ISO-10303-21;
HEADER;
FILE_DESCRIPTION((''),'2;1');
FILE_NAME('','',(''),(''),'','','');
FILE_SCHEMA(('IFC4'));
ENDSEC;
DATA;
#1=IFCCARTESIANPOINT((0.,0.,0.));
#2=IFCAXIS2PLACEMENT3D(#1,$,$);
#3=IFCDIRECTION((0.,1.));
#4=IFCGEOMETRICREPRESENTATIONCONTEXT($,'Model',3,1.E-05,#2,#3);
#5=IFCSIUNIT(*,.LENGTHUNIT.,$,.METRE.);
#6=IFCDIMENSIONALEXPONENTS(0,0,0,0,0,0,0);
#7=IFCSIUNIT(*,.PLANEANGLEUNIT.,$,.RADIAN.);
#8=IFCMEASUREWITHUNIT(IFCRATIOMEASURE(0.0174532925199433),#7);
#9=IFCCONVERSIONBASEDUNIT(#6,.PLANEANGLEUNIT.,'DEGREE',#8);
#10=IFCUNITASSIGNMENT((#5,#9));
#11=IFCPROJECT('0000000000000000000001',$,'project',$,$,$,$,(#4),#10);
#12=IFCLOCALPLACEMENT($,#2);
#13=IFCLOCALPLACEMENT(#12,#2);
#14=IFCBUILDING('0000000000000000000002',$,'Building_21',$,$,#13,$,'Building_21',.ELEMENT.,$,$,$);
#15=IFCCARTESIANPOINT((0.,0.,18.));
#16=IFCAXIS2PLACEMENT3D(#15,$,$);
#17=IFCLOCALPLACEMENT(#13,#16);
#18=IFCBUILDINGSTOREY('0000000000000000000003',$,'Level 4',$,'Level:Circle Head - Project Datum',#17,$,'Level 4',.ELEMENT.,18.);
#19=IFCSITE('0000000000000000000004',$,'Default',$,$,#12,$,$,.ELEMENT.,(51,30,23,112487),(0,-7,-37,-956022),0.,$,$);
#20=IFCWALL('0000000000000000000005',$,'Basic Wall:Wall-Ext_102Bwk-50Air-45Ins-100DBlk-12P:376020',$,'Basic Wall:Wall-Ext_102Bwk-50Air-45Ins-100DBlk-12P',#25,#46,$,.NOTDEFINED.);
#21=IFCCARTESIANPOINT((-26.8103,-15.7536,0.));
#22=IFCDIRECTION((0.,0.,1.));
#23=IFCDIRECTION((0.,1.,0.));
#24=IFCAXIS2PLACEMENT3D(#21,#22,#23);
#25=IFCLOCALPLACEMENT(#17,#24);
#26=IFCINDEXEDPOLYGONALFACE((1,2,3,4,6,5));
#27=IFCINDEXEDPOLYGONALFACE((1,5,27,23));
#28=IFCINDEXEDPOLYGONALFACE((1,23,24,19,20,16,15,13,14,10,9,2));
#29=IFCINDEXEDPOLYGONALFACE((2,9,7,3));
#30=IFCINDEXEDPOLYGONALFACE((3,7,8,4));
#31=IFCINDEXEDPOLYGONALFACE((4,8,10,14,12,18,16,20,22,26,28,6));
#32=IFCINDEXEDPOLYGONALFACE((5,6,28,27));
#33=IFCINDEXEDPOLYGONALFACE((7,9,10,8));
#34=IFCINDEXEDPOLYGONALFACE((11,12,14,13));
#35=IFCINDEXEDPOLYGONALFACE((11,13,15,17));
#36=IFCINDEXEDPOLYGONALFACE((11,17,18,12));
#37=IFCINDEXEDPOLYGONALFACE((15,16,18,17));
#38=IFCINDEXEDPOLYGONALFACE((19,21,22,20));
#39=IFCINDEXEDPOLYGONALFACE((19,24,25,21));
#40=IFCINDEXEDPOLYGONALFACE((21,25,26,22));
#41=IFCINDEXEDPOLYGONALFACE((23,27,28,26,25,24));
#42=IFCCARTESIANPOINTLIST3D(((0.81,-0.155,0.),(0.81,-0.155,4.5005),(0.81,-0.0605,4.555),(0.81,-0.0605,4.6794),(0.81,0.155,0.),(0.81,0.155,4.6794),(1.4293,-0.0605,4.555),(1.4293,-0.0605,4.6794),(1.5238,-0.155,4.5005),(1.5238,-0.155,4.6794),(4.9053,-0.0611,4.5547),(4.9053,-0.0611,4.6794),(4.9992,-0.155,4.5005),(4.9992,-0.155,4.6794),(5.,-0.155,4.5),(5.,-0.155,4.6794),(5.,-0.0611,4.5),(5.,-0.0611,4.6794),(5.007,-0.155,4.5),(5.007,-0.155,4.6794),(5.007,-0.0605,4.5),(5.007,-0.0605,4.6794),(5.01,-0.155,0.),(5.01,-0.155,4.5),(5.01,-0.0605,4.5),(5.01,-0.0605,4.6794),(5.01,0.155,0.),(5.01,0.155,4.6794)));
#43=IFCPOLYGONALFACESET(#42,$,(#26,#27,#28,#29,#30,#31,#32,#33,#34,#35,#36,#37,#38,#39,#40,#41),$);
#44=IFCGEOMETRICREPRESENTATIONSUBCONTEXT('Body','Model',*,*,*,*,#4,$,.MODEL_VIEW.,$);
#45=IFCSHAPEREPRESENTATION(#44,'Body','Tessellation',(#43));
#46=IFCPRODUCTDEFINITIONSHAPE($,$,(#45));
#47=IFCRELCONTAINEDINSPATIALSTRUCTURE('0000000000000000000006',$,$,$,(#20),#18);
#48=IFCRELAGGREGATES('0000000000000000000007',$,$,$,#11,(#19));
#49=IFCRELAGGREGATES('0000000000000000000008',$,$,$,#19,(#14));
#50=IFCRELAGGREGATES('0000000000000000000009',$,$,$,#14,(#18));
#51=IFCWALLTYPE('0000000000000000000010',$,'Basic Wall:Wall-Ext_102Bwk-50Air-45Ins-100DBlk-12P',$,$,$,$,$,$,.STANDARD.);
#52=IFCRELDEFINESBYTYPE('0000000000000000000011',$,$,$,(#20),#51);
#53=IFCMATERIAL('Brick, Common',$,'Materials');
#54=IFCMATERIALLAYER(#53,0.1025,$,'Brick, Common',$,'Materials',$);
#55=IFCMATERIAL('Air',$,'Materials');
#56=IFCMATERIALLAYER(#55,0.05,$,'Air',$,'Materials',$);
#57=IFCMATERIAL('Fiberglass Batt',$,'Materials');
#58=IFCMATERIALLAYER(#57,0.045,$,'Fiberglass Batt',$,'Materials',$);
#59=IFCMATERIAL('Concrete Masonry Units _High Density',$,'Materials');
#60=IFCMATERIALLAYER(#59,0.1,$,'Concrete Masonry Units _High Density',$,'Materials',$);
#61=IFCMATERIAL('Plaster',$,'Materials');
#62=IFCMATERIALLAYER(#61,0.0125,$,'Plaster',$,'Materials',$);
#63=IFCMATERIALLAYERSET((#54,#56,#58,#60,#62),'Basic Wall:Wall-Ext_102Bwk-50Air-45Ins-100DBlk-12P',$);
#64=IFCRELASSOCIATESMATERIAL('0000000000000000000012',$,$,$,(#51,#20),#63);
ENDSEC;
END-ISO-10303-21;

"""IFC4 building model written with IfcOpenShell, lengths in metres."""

from ifc_helpers import new_model, entity, si_unit, converted_unit, direction, frame, frame_2d, origin, place, context, subcontext, project, spatial, polyline, rectangle, extrude, clip, bounded_halfspace, material, layer, layer_set, layer_usage, type_object, element, save


model = new_model("IFC4")

# Units and contexts
model_context = context("Model", 3, precision=1e-05, world=origin(), true_north=direction((0.0, 1.0)))
body_context = subcontext(model_context, "Body", "Model", "MODEL_VIEW")
ifc_project = project(units=[si_unit("LENGTHUNIT", "METRE"), converted_unit("PLANEANGLEUNIT", "DEGREE", entity("IfcRatioMeasure", 0.0174532925199433), si_unit("PLANEANGLEUNIT", "RADIAN"), dimensions=[0, 0, 0, 0, 0, 0, 0])], contexts=[model_context])

# Site, building, storey
site_placement = place(None, origin())
site = spatial("IfcSite", under=ifc_project, at=site_placement, Name="Default", CompositionType="ELEMENT", RefLatitude=(51, 30, 23, 112487), RefLongitude=(0, -7, -37, -956022), RefElevation=0.0)
building_placement = place(site_placement, origin())
building = spatial("IfcBuilding", under=site, at=building_placement, Name="Building_21", LongName="Building_21", CompositionType="ELEMENT")
storey_placement = place(building_placement, frame((0.0, 0.0, 18.0)))
storey = spatial("IfcBuildingStorey", under=building, at=storey_placement, Name="Level 4", ObjectType="Level:Circle Head - Project Datum", LongName="Level 4", CompositionType="ELEMENT", Elevation=18.0)

# Shared definitions
ifc_material_1 = material(Name="Air", Category="Materials")

# Shared definitions
ifc_material_2 = material(Name="Brick, Common", Category="Materials")
ifc_layer_1 = layer(ifc_material_2, 0.1025, Name="Brick, Common", Category="Materials")
ifc_layer_2 = layer(ifc_material_1, 0.05, Name="Air", Category="Materials")
ifc_material_3 = material(Name="Fiberglass Batt", Category="Materials")
ifc_layer_3 = layer(ifc_material_3, 0.045, Name="Fiberglass Batt", Category="Materials")
ifc_material_4 = material(Name="Concrete Masonry Units _High Density", Category="Materials")
ifc_layer_4 = layer(ifc_material_4, 0.1, Name="Concrete Masonry Units _High Density", Category="Materials")
ifc_material_5 = material(Name="Plaster", Category="Materials")
ifc_layer_5 = layer(ifc_material_5, 0.0125, Name="Plaster", Category="Materials")
ifc_layer_set_1 = layer_set([ifc_layer_1, ifc_layer_2, ifc_layer_3, ifc_layer_4, ifc_layer_5], Name="Basic Wall:Wall-Ext_102Bwk-50Air-45Ins-100DBlk-12P")
wall_type = type_object("IfcWallType", Name="Basic Wall:Wall-Ext_102Bwk-50Air-45Ins-100DBlk-12P", PredefinedType="STANDARD", material=ifc_layer_set_1)

# Wall, opening
ifc_layer_usage_1 = layer_usage(ifc_layer_set_1, "AXIS2", "NEGATIVE", 0.155)
wall_1_placement = place(storey_placement, frame((-26.8103, -15.7536, 0.0), z_axis=(0.0, 0.0, 1.0), x_axis=(0.0, 1.0, 0.0)))
wall_1 = element("IfcWall", 1, at=wall_1_placement, inside=storey, type_object=wall_type, material=ifc_layer_usage_1, Name="Basic Wall:Wall-Ext_102Bwk-50Air-45Ins-100DBlk-12P:376020", ObjectType="Basic Wall:Wall-Ext_102Bwk-50Air-45Ins-100DBlk-12P", PredefinedType="NOTDEFINED", context=body_context, shape_type="Clipping", body=[
    clip(clip(clip(clip(extrude(rectangle(XDim=0.31, YDim=4.2, at=frame_2d((2.91, 0.0), x_axis=(0.0, -1.0))), origin(), (0.0, 0.0, 1.0), 4.6794), bounded_halfspace(frame((5.0, -0.1558, 4.5), z_axis=(0.5, 0.0, 0.866025), x_axis=(0.0, 1.0, 0.0)), False, frame((5.0, -0.1558, 4.5)), polyline([(0.0, 0.0), (0.0, 0.0947), (-0.0947, 0.0947), (0.0, 0.0)]))), bounded_halfspace(frame((0.0, -0.155, 4.5005), z_axis=(0.0, -0.5, 0.866025), x_axis=(1.0, 0.0, 0.0)), False, frame((0.0, -0.155, 4.5005)), polyline([(0.0, 0.0), (1.5238, 0.0), (1.4293, 0.0945), (0.0, 0.0945), (0.0, 0.0)]))), bounded_halfspace(frame((0.0008, 0.155, 4.6794), z_axis=(-0.5, 0.0, 0.866025), x_axis=(0.0, -1.0, 0.0)), False, frame((0.0008, 0.155, 4.6794)), polyline([(0.0, 0.0), (-0.0002, 0.0), (-0.0002, -0.0002), (0.0, 0.0)]))), bounded_halfspace(frame((5.01, -0.155, 4.5), z_axis=(0.0, 0.0, 1.0), x_axis=(0.0, 1.0, 0.0)), False, frame((5.01, -0.155, 4.5)), polyline([(0.0, 0.0), (0.0, 0.0945), (-0.003, 0.0945), (-0.003, 0.0), (0.0, 0.0)]))),
])
opening_1_placement = place(wall_1_placement, frame((0.0, -0.155, 0.0)))
element("IfcOpeningElement", 2, at=opening_1_placement, cuts=wall_1, PredefinedType="OPENING", context=body_context, shape_type="SweptSolid", body=[
    extrude(rectangle(XDim=2.11, YDim=0.81, at=frame_2d((1.055, 0.405), x_axis=(1.0, 0.0))), frame((0.0, 0.0, 0.0), z_axis=(0.0, 1.0, 0.0), x_axis=(0.0, 0.0, 1.0)), (0.0, 0.0, 1.0), 0.31),
])

save(model, "model.ifc")
